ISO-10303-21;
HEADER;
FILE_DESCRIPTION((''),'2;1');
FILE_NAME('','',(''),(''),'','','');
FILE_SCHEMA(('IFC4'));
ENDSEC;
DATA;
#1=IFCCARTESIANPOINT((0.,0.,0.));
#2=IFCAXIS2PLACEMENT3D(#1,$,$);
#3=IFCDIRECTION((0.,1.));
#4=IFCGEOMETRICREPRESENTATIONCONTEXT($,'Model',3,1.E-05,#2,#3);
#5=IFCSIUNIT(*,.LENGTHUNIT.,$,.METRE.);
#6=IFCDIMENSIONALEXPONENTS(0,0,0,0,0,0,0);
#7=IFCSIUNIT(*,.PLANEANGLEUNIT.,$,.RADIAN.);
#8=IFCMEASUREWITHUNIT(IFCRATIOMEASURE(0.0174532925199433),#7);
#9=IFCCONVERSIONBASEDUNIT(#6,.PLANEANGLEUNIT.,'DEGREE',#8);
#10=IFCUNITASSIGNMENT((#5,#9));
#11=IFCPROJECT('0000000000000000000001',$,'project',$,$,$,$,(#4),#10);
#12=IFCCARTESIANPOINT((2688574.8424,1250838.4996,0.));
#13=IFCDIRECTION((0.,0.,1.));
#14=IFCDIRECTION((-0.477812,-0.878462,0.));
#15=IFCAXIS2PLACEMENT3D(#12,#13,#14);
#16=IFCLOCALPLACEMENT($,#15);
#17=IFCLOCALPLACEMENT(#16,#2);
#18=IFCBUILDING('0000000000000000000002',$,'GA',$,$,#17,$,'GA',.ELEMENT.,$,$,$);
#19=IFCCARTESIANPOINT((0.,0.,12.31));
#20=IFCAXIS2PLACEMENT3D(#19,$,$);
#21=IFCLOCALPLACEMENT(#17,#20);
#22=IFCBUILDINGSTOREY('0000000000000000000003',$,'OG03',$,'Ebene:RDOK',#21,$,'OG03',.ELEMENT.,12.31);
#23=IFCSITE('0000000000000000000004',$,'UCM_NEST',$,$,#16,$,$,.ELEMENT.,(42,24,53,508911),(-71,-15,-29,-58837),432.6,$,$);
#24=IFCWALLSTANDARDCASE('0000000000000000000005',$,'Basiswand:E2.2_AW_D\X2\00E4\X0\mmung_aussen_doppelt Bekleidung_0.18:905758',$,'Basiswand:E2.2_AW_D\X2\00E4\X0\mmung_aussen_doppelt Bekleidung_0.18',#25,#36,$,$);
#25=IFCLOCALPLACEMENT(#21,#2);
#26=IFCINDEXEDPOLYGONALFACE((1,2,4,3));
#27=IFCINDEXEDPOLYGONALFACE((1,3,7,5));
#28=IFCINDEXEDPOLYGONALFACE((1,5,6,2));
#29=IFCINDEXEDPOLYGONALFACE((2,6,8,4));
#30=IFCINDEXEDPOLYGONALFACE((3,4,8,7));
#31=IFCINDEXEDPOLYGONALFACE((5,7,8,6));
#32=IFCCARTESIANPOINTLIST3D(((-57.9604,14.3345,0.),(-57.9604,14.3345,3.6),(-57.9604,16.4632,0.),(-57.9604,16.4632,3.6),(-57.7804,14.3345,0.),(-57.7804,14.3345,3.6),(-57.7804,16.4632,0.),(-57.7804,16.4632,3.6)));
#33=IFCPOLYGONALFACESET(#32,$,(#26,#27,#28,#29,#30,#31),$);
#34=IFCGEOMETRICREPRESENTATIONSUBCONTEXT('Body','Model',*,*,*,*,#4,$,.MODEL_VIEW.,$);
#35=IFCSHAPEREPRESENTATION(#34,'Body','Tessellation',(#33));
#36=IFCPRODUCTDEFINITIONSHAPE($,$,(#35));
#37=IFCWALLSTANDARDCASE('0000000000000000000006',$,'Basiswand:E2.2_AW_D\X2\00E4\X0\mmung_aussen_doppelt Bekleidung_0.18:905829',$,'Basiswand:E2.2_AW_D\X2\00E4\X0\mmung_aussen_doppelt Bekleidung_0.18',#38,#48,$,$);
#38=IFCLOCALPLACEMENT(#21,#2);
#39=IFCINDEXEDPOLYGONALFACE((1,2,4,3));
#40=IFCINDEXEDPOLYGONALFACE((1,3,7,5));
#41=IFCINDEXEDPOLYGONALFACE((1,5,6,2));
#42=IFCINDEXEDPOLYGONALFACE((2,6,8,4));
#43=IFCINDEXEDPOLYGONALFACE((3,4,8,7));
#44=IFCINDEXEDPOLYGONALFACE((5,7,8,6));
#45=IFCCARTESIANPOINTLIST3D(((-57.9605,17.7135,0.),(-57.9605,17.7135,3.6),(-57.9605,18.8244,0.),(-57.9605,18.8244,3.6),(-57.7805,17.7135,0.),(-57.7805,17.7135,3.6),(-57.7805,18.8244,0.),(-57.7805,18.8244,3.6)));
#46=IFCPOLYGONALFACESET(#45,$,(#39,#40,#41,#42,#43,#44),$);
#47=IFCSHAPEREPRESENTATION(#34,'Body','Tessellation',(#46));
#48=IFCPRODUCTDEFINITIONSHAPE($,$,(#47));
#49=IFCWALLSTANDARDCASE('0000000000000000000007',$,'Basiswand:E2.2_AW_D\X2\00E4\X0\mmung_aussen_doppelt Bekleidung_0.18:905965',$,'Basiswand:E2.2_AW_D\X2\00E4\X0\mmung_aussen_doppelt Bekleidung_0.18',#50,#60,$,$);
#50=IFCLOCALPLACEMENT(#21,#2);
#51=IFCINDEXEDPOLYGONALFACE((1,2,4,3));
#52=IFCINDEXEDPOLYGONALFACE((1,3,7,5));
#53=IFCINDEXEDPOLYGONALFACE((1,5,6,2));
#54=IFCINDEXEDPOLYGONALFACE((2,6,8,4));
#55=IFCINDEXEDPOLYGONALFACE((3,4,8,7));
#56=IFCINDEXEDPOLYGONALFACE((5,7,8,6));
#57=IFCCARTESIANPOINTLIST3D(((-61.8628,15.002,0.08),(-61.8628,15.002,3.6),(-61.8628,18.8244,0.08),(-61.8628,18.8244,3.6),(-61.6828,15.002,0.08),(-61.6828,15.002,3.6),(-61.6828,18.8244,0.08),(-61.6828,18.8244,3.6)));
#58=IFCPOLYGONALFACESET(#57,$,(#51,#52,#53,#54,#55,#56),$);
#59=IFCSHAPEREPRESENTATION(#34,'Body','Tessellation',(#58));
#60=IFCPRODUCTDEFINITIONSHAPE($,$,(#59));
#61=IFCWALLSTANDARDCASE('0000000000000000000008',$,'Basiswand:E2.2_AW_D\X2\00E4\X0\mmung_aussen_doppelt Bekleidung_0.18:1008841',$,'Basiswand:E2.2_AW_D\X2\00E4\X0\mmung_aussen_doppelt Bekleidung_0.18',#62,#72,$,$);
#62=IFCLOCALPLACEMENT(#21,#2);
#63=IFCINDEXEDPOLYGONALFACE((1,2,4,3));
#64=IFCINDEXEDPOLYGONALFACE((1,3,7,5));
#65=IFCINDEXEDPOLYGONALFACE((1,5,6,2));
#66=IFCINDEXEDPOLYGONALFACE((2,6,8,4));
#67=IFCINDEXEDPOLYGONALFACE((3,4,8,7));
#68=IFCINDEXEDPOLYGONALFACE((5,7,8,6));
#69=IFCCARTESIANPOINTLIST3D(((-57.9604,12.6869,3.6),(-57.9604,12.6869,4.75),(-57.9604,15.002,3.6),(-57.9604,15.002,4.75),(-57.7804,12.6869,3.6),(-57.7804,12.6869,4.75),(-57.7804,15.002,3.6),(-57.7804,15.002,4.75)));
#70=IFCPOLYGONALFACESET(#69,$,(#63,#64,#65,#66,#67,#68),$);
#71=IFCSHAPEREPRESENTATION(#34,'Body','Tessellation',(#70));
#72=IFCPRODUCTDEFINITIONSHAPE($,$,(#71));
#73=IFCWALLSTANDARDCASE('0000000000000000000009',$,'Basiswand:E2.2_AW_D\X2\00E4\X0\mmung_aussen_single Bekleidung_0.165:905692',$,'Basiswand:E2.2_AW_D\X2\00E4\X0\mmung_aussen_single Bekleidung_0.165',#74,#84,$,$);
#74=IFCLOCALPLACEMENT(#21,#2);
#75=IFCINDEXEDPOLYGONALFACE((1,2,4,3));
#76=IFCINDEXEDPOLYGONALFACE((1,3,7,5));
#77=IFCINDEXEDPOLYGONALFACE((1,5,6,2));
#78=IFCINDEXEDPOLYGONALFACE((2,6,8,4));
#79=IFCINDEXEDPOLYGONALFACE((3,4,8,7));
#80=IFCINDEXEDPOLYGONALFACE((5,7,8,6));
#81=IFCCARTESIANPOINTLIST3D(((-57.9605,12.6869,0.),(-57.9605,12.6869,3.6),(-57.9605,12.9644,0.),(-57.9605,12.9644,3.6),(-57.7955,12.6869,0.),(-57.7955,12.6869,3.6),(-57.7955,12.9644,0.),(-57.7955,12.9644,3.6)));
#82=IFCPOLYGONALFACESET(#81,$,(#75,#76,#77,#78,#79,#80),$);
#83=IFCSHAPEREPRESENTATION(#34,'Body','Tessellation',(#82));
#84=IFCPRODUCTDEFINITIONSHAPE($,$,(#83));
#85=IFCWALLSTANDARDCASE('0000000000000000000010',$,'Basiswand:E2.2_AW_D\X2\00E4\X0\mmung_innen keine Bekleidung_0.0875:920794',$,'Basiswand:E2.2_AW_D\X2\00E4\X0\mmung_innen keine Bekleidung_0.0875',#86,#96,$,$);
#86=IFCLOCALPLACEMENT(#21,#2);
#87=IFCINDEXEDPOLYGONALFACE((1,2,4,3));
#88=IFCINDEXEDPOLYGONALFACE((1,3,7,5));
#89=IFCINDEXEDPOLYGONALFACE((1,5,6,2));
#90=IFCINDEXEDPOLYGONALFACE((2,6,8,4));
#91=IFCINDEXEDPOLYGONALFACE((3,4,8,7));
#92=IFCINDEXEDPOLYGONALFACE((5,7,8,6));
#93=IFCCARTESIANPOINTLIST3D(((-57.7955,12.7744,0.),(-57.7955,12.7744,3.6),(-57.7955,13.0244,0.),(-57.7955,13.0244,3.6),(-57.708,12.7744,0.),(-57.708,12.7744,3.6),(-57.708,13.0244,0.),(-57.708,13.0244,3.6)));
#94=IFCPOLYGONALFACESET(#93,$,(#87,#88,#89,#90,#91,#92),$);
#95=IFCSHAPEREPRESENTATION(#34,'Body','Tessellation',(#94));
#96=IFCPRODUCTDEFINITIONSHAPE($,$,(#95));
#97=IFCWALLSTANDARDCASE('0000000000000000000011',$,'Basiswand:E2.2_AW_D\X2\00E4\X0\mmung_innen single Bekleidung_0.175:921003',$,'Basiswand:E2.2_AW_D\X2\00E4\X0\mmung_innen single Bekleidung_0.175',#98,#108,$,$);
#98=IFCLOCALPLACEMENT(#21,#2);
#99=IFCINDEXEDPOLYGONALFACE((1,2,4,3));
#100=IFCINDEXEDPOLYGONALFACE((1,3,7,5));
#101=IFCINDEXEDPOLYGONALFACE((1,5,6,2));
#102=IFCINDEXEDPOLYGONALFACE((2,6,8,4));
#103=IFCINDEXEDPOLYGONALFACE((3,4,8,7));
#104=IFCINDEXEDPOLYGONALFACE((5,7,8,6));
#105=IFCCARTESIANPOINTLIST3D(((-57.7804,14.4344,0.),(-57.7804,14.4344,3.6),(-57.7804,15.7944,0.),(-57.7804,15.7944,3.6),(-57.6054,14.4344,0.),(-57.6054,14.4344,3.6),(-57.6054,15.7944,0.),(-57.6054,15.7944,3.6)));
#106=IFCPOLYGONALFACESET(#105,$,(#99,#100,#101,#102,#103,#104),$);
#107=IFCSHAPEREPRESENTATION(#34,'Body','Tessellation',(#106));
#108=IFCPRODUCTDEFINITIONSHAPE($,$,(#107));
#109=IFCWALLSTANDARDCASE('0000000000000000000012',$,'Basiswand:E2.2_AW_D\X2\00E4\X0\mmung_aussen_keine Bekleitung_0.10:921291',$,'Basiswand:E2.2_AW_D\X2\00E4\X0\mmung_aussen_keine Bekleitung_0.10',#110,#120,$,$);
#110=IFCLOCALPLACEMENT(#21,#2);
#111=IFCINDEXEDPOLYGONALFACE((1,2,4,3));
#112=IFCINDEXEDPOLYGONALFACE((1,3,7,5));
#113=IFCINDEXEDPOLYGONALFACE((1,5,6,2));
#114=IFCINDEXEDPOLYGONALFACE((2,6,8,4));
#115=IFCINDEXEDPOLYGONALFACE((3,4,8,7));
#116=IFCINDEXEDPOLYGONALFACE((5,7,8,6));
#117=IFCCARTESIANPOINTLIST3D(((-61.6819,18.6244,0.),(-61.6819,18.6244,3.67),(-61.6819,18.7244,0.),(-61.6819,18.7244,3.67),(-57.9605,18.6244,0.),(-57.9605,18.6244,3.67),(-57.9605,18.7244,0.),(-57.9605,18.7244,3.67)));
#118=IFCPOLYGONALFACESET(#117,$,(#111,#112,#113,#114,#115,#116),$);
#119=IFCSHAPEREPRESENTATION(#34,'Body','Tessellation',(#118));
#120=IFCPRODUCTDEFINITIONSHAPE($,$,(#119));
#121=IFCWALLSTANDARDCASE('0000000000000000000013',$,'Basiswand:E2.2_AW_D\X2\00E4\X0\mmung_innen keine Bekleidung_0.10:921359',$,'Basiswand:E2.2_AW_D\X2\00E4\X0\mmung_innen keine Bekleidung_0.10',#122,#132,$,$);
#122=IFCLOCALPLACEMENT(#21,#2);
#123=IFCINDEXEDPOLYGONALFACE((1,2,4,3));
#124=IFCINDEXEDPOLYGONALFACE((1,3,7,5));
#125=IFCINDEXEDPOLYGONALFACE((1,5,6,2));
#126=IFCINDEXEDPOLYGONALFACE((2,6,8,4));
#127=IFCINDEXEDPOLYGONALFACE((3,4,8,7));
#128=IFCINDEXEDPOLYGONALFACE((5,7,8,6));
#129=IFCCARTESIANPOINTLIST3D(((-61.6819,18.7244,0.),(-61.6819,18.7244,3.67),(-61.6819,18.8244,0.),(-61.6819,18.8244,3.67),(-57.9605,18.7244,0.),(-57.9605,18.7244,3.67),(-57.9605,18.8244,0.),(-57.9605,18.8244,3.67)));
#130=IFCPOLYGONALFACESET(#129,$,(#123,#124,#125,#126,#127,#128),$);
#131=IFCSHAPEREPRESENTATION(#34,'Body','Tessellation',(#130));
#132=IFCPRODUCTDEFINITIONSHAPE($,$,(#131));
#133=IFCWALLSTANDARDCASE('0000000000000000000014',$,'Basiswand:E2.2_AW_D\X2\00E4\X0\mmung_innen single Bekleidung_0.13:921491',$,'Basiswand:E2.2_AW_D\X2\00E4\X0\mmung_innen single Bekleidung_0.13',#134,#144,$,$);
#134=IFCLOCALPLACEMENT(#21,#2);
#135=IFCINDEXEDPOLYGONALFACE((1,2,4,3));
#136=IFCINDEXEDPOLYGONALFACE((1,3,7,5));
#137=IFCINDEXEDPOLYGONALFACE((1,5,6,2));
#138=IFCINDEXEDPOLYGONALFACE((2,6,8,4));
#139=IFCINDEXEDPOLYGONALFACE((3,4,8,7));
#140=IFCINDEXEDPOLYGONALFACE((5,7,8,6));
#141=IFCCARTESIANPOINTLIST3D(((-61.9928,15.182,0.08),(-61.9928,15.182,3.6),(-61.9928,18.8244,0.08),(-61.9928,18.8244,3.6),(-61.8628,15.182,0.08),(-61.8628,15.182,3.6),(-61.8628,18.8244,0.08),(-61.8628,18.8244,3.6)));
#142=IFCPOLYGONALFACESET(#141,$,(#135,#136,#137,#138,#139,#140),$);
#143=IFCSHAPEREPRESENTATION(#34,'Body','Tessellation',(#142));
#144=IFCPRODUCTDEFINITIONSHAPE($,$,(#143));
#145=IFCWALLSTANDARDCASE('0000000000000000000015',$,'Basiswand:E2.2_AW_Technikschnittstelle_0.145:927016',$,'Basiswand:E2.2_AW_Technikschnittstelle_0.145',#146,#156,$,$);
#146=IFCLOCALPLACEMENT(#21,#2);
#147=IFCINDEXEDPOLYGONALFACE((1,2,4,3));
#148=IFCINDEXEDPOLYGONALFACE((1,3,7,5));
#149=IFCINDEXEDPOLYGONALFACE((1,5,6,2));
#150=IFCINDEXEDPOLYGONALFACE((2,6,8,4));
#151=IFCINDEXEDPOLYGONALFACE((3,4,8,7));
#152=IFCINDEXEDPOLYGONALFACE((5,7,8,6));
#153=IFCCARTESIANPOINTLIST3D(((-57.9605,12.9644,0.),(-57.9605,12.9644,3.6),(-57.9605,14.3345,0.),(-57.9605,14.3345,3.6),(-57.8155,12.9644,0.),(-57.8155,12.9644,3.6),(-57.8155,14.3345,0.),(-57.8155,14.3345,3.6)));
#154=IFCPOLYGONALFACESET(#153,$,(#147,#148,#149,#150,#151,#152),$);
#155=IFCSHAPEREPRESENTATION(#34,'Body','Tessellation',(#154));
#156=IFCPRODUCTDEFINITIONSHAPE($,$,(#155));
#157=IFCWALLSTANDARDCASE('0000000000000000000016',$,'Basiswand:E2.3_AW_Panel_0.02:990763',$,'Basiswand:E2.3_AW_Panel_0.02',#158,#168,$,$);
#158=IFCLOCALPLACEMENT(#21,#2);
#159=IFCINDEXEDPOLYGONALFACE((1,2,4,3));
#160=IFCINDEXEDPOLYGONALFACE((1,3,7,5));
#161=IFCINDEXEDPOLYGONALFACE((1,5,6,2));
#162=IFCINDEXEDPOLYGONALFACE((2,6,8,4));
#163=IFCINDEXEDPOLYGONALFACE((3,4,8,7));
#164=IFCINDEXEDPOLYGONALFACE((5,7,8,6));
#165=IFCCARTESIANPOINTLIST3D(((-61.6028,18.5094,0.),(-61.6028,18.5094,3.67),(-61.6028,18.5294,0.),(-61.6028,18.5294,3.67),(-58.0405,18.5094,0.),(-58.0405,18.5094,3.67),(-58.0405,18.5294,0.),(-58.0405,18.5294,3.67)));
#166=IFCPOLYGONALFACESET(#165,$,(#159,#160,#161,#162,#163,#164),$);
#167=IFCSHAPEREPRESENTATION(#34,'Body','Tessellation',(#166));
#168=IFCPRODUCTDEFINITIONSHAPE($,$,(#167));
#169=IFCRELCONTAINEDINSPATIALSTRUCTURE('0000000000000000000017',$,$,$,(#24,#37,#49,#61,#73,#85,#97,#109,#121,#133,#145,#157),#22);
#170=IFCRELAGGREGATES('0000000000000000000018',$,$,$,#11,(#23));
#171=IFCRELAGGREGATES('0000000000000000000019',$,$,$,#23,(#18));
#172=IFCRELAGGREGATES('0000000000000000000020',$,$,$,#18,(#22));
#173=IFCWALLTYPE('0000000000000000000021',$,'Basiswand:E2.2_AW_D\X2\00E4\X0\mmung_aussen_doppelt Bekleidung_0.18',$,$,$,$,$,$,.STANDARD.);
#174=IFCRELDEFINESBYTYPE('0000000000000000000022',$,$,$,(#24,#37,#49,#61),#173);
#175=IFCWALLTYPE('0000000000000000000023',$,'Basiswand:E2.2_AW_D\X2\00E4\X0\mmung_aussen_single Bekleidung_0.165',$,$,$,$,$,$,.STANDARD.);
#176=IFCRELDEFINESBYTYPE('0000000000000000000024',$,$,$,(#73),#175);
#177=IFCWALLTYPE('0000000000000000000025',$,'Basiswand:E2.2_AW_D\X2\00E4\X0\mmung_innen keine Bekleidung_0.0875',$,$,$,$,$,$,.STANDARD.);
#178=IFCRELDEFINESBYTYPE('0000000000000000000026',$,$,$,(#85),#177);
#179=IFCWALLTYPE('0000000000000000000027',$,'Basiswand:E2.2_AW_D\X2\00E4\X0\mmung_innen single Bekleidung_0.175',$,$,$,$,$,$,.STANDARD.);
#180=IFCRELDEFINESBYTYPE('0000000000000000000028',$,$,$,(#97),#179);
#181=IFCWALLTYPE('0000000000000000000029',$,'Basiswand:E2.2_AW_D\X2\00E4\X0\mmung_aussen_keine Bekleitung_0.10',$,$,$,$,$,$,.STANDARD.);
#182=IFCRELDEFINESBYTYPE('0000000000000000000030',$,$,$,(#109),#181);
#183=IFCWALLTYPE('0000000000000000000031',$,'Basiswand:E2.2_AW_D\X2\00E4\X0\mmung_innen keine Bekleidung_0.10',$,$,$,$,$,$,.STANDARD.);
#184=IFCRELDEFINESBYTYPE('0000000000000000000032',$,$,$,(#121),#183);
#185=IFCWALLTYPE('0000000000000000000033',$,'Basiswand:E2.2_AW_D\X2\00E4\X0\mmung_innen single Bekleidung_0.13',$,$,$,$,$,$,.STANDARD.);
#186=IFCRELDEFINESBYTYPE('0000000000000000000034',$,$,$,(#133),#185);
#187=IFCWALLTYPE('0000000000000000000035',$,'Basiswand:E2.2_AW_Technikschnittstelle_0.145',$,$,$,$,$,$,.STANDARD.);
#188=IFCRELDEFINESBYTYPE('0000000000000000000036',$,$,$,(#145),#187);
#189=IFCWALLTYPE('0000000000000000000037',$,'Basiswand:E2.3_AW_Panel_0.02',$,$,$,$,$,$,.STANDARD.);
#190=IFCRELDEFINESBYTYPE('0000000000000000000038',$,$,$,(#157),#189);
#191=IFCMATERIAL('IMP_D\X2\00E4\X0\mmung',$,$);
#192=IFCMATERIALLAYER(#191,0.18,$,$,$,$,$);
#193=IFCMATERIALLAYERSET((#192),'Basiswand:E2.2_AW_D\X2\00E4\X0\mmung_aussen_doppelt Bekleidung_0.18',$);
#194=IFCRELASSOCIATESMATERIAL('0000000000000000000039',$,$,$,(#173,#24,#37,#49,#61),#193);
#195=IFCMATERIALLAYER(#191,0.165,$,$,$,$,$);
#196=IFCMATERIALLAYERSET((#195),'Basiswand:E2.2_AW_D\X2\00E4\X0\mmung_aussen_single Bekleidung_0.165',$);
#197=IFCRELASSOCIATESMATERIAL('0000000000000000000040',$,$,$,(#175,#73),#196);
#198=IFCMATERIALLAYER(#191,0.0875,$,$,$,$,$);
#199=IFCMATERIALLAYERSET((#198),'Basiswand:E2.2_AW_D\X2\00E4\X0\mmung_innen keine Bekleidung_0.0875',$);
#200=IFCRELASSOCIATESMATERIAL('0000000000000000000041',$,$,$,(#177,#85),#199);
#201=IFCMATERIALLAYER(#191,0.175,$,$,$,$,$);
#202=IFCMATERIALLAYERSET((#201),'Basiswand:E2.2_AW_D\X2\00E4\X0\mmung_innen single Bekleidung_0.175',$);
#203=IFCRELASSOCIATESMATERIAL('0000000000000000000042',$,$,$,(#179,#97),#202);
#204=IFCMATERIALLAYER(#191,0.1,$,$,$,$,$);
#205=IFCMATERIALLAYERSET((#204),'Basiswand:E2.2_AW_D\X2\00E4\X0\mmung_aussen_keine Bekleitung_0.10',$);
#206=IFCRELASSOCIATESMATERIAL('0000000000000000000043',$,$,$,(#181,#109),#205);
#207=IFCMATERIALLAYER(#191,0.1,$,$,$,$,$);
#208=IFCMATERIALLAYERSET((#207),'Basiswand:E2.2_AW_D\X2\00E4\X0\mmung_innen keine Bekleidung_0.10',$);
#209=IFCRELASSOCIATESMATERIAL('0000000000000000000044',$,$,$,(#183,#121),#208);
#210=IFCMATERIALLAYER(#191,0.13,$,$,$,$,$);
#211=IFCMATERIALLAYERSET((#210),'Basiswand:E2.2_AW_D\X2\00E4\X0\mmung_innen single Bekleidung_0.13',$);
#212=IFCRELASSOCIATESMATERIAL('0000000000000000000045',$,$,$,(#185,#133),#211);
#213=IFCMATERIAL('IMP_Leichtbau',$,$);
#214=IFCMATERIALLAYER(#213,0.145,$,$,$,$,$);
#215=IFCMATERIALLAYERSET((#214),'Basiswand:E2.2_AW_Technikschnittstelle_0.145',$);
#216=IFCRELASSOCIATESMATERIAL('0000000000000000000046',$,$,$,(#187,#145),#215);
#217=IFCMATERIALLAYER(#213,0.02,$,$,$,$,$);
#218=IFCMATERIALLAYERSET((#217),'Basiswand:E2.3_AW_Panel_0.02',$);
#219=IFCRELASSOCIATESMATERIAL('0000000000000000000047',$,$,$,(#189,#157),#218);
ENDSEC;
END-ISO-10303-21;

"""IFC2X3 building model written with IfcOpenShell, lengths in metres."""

from ifc_helpers import new_model, entity, si_unit, converted_unit, direction, frame, frame_2d, origin, place, context, subcontext, project, spatial, polyline, rectangle, extrude, clip, bounded_halfspace, material, layer, layer_set, layer_usage, type_object, element, save


model = new_model("IFC2X3")

# Units and contexts
model_context = context("Model", 3, precision=1e-05, world=origin(), true_north=direction((0.0, 1.0)))
body_context = subcontext(model_context, "Body", "Model", "MODEL_VIEW")
ifc_project = project(units=[si_unit("LENGTHUNIT", "METRE"), converted_unit("PLANEANGLEUNIT", "DEGREE", entity("IfcRatioMeasure", 0.0174532925199433), si_unit("PLANEANGLEUNIT", "RADIAN"), dimensions=[0, 0, 0, 0, 0, 0, 0])], contexts=[model_context])

# Site, building, storey
site_placement = place(None, frame((2688574.8424, 1250838.4996, 0.0), z_axis=(0.0, 0.0, 1.0), x_axis=(-0.477812, -0.878462, 0.0)))
site = spatial("IfcSite", under=ifc_project, at=site_placement, Name="UCM_NEST", CompositionType="ELEMENT", RefLatitude=(42, 24, 53, 508911), RefLongitude=(-71, -15, -29, -58837), RefElevation=432.6)
building_placement = place(site_placement, origin())
building = spatial("IfcBuilding", under=site, at=building_placement, Name="GA", LongName="GA", CompositionType="ELEMENT")
storey_placement = place(building_placement, frame((0.0, 0.0, 12.31)))
storey = spatial("IfcBuildingStorey", under=building, at=storey_placement, Name="OG03", ObjectType="Ebene:RDOK", LongName="OG03", CompositionType="ELEMENT", Elevation=12.31)

# Walls
ifc_material_1 = material(Name="IMP_Dämmung")
ifc_layer_1 = layer(ifc_material_1, 0.18)
ifc_layer_set_1 = layer_set([ifc_layer_1], Name="Basiswand:E2.2_AW_Dämmung_aussen_doppelt Bekleidung_0.18")
ifc_layer_usage_1 = layer_usage(ifc_layer_set_1, "AXIS2", "NEGATIVE", 0.09)
wall_type_1 = type_object("IfcWallType", Name="Basiswand:E2.2_AW_Dämmung_aussen_doppelt Bekleidung_0.18", PredefinedType="STANDARD", material=ifc_layer_set_1)
wall_1_placement = place(storey_placement, frame((-57.8704, 14.3345, 0.0), z_axis=(0.0, 0.0, 1.0), x_axis=(0.0, 1.0, 0.0)))
element("IfcWallStandardCase", 1, at=wall_1_placement, inside=storey, type_object=wall_type_1, material=ifc_layer_usage_1, Name="Basiswand:E2.2_AW_Dämmung_aussen_doppelt Bekleidung_0.18:905758", ObjectType="Basiswand:E2.2_AW_Dämmung_aussen_doppelt Bekleidung_0.18", context=body_context, shape_type="SweptSolid", body=[
    extrude(rectangle(XDim=2.1287, YDim=0.18, at=frame_2d((1.0644, 0.0), x_axis=(-1.0, 0.0))), origin(), (0.0, 0.0, 1.0), 3.6),
])
ifc_layer_usage_2 = layer_usage(ifc_layer_set_1, "AXIS2", "NEGATIVE", 0.09)
wall_2_placement = place(storey_placement, frame((-57.8705, 17.7135, 0.0), z_axis=(0.0, 0.0, 1.0), x_axis=(0.0, 1.0, 0.0)))
element("IfcWallStandardCase", 2, at=wall_2_placement, inside=storey, type_object=wall_type_1, material=ifc_layer_usage_2, Name="Basiswand:E2.2_AW_Dämmung_aussen_doppelt Bekleidung_0.18:905829", ObjectType="Basiswand:E2.2_AW_Dämmung_aussen_doppelt Bekleidung_0.18", context=body_context, shape_type="SweptSolid", body=[
    extrude(rectangle(XDim=1.111, YDim=0.18, at=frame_2d((0.5555, 0.0), x_axis=(-1.0, 0.0))), origin(), (0.0, 0.0, 1.0), 3.6),
])
ifc_layer_usage_3 = layer_usage(ifc_layer_set_1, "AXIS2", "NEGATIVE", 0.09)
wall_3_placement = place(storey_placement, frame((-61.7728, 18.8244, 0.08), z_axis=(0.0, 0.0, 1.0), x_axis=(0.0, -1.0, 0.0)))
element("IfcWallStandardCase", 3, at=wall_3_placement, inside=storey, type_object=wall_type_1, material=ifc_layer_usage_3, Name="Basiswand:E2.2_AW_Dämmung_aussen_doppelt Bekleidung_0.18:905965", ObjectType="Basiswand:E2.2_AW_Dämmung_aussen_doppelt Bekleidung_0.18", context=body_context, shape_type="Clipping", body=[
    clip(extrude(rectangle(XDim=3.8225, YDim=0.18, at=frame_2d((1.9112, 0.0), x_axis=(-1.0, 0.0))), origin(), (0.0, 0.0, 1.0), 3.52), bounded_halfspace(frame((3.8225, -0.09, 0.0), z_axis=(0.0, 0.0, 1.0), x_axis=(0.0, -1.0, 0.0)), True, frame((3.8225, -0.09, 0.0), z_axis=(0.0, 0.0, 1.0), x_axis=(0.0, -1.0, 0.0)), polyline([(0.0, 0.0), (-0.18, 0.0), (-0.18, -3.8225), (0.0, -3.8225), (0.0, -0.18), (0.0, 0.0)]))),
])
ifc_layer_usage_4 = layer_usage(ifc_layer_set_1, "AXIS2", "NEGATIVE", 0.09)
wall_4_placement = place(storey_placement, frame((-57.8704, 15.002, 3.6), z_axis=(0.0, 0.0, 1.0), x_axis=(0.0, -1.0, 0.0)))
element("IfcWallStandardCase", 4, at=wall_4_placement, inside=storey, type_object=wall_type_1, material=ifc_layer_usage_4, Name="Basiswand:E2.2_AW_Dämmung_aussen_doppelt Bekleidung_0.18:1008841", ObjectType="Basiswand:E2.2_AW_Dämmung_aussen_doppelt Bekleidung_0.18", context=body_context, shape_type="SweptSolid", body=[
    extrude(rectangle(XDim=2.315, YDim=0.18, at=frame_2d((1.1575, 0.0), x_axis=(-1.0, 0.0))), origin(), (0.0, 0.0, 1.0), 1.15),
])
ifc_layer_2 = layer(ifc_material_1, 0.165)
ifc_layer_set_2 = layer_set([ifc_layer_2], Name="Basiswand:E2.2_AW_Dämmung_aussen_single Bekleidung_0.165")
ifc_layer_usage_5 = layer_usage(ifc_layer_set_2, "AXIS2", "NEGATIVE", 0.0825)
wall_type_2 = type_object("IfcWallType", Name="Basiswand:E2.2_AW_Dämmung_aussen_single Bekleidung_0.165", PredefinedType="STANDARD", material=ifc_layer_set_2)
wall_5_placement = place(storey_placement, frame((-57.878, 12.6869, 0.0), z_axis=(0.0, 0.0, 1.0), x_axis=(0.0, 1.0, 0.0)))
element("IfcWallStandardCase", 5, at=wall_5_placement, inside=storey, type_object=wall_type_2, material=ifc_layer_usage_5, Name="Basiswand:E2.2_AW_Dämmung_aussen_single Bekleidung_0.165:905692", ObjectType="Basiswand:E2.2_AW_Dämmung_aussen_single Bekleidung_0.165", context=body_context, shape_type="SweptSolid", body=[
    extrude(rectangle(XDim=0.2775, YDim=0.165, at=frame_2d((0.1387, 0.0), x_axis=(-1.0, 0.0))), origin(), (0.0, 0.0, 1.0), 3.6),
])
ifc_layer_3 = layer(ifc_material_1, 0.0875)
ifc_layer_set_3 = layer_set([ifc_layer_3], Name="Basiswand:E2.2_AW_Dämmung_innen keine Bekleidung_0.0875")
ifc_layer_usage_6 = layer_usage(ifc_layer_set_3, "AXIS2", "NEGATIVE", 0.0437)
wall_type_3 = type_object("IfcWallType", Name="Basiswand:E2.2_AW_Dämmung_innen keine Bekleidung_0.0875", PredefinedType="STANDARD", material=ifc_layer_set_3)
wall_6_placement = place(storey_placement, frame((-57.7517, 12.7744, 0.0), z_axis=(0.0, 0.0, 1.0), x_axis=(0.0, 1.0, 0.0)))
element("IfcWallStandardCase", 6, at=wall_6_placement, inside=storey, type_object=wall_type_3, material=ifc_layer_usage_6, Name="Basiswand:E2.2_AW_Dämmung_innen keine Bekleidung_0.0875:920794", ObjectType="Basiswand:E2.2_AW_Dämmung_innen keine Bekleidung_0.0875", context=body_context, shape_type="SweptSolid", body=[
    extrude(rectangle(XDim=0.25, YDim=0.0875, at=frame_2d((0.125, 0.0), x_axis=(-1.0, 0.0))), origin(), (0.0, 0.0, 1.0), 3.6),
])
ifc_layer_4 = layer(ifc_material_1, 0.175)
ifc_layer_set_4 = layer_set([ifc_layer_4], Name="Basiswand:E2.2_AW_Dämmung_innen single Bekleidung_0.175")
ifc_layer_usage_7 = layer_usage(ifc_layer_set_4, "AXIS2", "NEGATIVE", 0.0875)
wall_type_4 = type_object("IfcWallType", Name="Basiswand:E2.2_AW_Dämmung_innen single Bekleidung_0.175", PredefinedType="STANDARD", material=ifc_layer_set_4)
wall_7_placement = place(storey_placement, frame((-57.6929, 14.4344, 0.0), z_axis=(0.0, 0.0, 1.0), x_axis=(0.0, 1.0, 0.0)))
element("IfcWallStandardCase", 7, at=wall_7_placement, inside=storey, type_object=wall_type_4, material=ifc_layer_usage_7, Name="Basiswand:E2.2_AW_Dämmung_innen single Bekleidung_0.175:921003", ObjectType="Basiswand:E2.2_AW_Dämmung_innen single Bekleidung_0.175", context=body_context, shape_type="SweptSolid", body=[
    extrude(rectangle(XDim=1.36, YDim=0.175, at=frame_2d((0.68, 0.0), x_axis=(-1.0, 0.0))), origin(), (0.0, 0.0, 1.0), 3.6),
])
ifc_layer_5 = layer(ifc_material_1, 0.1)
ifc_layer_set_5 = layer_set([ifc_layer_5], Name="Basiswand:E2.2_AW_Dämmung_aussen_keine Bekleitung_0.10")
ifc_layer_usage_8 = layer_usage(ifc_layer_set_5, "AXIS2", "NEGATIVE", 0.05)
wall_type_5 = type_object("IfcWallType", Name="Basiswand:E2.2_AW_Dämmung_aussen_keine Bekleitung_0.10", PredefinedType="STANDARD", material=ifc_layer_set_5)
wall_8_placement = place(storey_placement, frame((-57.9605, 18.6744, 0.0), z_axis=(0.0, 0.0, 1.0), x_axis=(-1.0, 0.0, 0.0)))
element("IfcWallStandardCase", 8, at=wall_8_placement, inside=storey, type_object=wall_type_5, material=ifc_layer_usage_8, Name="Basiswand:E2.2_AW_Dämmung_aussen_keine Bekleitung_0.10:921291", ObjectType="Basiswand:E2.2_AW_Dämmung_aussen_keine Bekleitung_0.10", context=body_context, shape_type="SweptSolid", body=[
    extrude(rectangle(XDim=3.7214, YDim=0.1, at=frame_2d((1.8607, 0.0), x_axis=(-1.0, 0.0))), origin(), (0.0, 0.0, 1.0), 3.67),
])
ifc_layer_6 = layer(ifc_material_1, 0.1)
ifc_layer_set_6 = layer_set([ifc_layer_6], Name="Basiswand:E2.2_AW_Dämmung_innen keine Bekleidung_0.10")
ifc_layer_usage_9 = layer_usage(ifc_layer_set_6, "AXIS2", "NEGATIVE", 0.05)
wall_type_6 = type_object("IfcWallType", Name="Basiswand:E2.2_AW_Dämmung_innen keine Bekleidung_0.10", PredefinedType="STANDARD", material=ifc_layer_set_6)
wall_9_placement = place(storey_placement, frame((-57.9605, 18.7744, 0.0), z_axis=(0.0, 0.0, 1.0), x_axis=(-1.0, 0.0, 0.0)))
element("IfcWallStandardCase", 9, at=wall_9_placement, inside=storey, type_object=wall_type_6, material=ifc_layer_usage_9, Name="Basiswand:E2.2_AW_Dämmung_innen keine Bekleidung_0.10:921359", ObjectType="Basiswand:E2.2_AW_Dämmung_innen keine Bekleidung_0.10", context=body_context, shape_type="SweptSolid", body=[
    extrude(rectangle(XDim=3.7214, YDim=0.1, at=frame_2d((1.8607, 0.0), x_axis=(-1.0, 0.0))), origin(), (0.0, 0.0, 1.0), 3.67),
])
ifc_layer_7 = layer(ifc_material_1, 0.13)
ifc_layer_set_7 = layer_set([ifc_layer_7], Name="Basiswand:E2.2_AW_Dämmung_innen single Bekleidung_0.13")
ifc_layer_usage_10 = layer_usage(ifc_layer_set_7, "AXIS2", "NEGATIVE", 0.065)
wall_type_7 = type_object("IfcWallType", Name="Basiswand:E2.2_AW_Dämmung_innen single Bekleidung_0.13", PredefinedType="STANDARD", material=ifc_layer_set_7)
wall_10_placement = place(storey_placement, frame((-61.9278, 18.8244, 0.08), z_axis=(0.0, 0.0, 1.0), x_axis=(0.0, -1.0, 0.0)))
element("IfcWallStandardCase", 10, at=wall_10_placement, inside=storey, type_object=wall_type_7, material=ifc_layer_usage_10, Name="Basiswand:E2.2_AW_Dämmung_innen single Bekleidung_0.13:921491", ObjectType="Basiswand:E2.2_AW_Dämmung_innen single Bekleidung_0.13", context=body_context, shape_type="Clipping", body=[
    clip(extrude(rectangle(XDim=3.6425, YDim=0.13, at=frame_2d((1.8212, 0.0), x_axis=(-1.0, 0.0))), origin(), (0.0, 0.0, 1.0), 3.52), bounded_halfspace(frame((3.6425, -0.065, 0.0), z_axis=(0.0, 0.0, 1.0), x_axis=(0.0, -1.0, 0.0)), True, frame((3.6425, -0.065, 0.0), z_axis=(0.0, 0.0, 1.0), x_axis=(0.0, -1.0, 0.0)), polyline([(0.0, 0.0), (-0.13, 0.0), (-0.13, -3.6425), (0.0, -3.6425), (0.0, -0.13), (0.0, 0.0)]))),
])
ifc_material_2 = material(Name="IMP_Leichtbau")
ifc_layer_8 = layer(ifc_material_2, 0.145)
ifc_layer_set_8 = layer_set([ifc_layer_8], Name="Basiswand:E2.2_AW_Technikschnittstelle_0.145")
ifc_layer_usage_11 = layer_usage(ifc_layer_set_8, "AXIS2", "NEGATIVE", 0.0725)
wall_type_8 = type_object("IfcWallType", Name="Basiswand:E2.2_AW_Technikschnittstelle_0.145", PredefinedType="STANDARD", material=ifc_layer_set_8)
wall_11_placement = place(storey_placement, frame((-57.888, 12.9644, 0.0), z_axis=(0.0, 0.0, 1.0), x_axis=(0.0, 1.0, 0.0)))
element("IfcWallStandardCase", 11, at=wall_11_placement, inside=storey, type_object=wall_type_8, material=ifc_layer_usage_11, Name="Basiswand:E2.2_AW_Technikschnittstelle_0.145:927016", ObjectType="Basiswand:E2.2_AW_Technikschnittstelle_0.145", context=body_context, shape_type="SweptSolid", body=[
    extrude(rectangle(XDim=1.3701, YDim=0.145, at=frame_2d((0.685, 0.0), x_axis=(-1.0, 0.0))), origin(), (0.0, 0.0, 1.0), 3.6),
])

# Wall
ifc_layer_9 = layer(ifc_material_2, 0.02)
ifc_layer_set_9 = layer_set([ifc_layer_9], Name="Basiswand:E2.3_AW_Panel_0.02")
ifc_layer_usage_12 = layer_usage(ifc_layer_set_9, "AXIS2", "NEGATIVE", 0.01)
wall_type_9 = type_object("IfcWallType", Name="Basiswand:E2.3_AW_Panel_0.02", PredefinedType="STANDARD", material=ifc_layer_set_9)
wall_12_placement = place(storey_placement, frame((-58.0405, 18.5194, 0.0), z_axis=(0.0, 0.0, 1.0), x_axis=(-1.0, 0.0, 0.0)))
element("IfcWallStandardCase", 12, at=wall_12_placement, inside=storey, type_object=wall_type_9, material=ifc_layer_usage_12, Name="Basiswand:E2.3_AW_Panel_0.02:990763", ObjectType="Basiswand:E2.3_AW_Panel_0.02", context=body_context, shape_type="SweptSolid", body=[
    extrude(rectangle(XDim=3.5623, YDim=0.02, at=frame_2d((1.7811, 0.0), x_axis=(-1.0, 0.0))), origin(), (0.0, 0.0, 1.0), 3.67),
])

save(model, "model.ifc")
